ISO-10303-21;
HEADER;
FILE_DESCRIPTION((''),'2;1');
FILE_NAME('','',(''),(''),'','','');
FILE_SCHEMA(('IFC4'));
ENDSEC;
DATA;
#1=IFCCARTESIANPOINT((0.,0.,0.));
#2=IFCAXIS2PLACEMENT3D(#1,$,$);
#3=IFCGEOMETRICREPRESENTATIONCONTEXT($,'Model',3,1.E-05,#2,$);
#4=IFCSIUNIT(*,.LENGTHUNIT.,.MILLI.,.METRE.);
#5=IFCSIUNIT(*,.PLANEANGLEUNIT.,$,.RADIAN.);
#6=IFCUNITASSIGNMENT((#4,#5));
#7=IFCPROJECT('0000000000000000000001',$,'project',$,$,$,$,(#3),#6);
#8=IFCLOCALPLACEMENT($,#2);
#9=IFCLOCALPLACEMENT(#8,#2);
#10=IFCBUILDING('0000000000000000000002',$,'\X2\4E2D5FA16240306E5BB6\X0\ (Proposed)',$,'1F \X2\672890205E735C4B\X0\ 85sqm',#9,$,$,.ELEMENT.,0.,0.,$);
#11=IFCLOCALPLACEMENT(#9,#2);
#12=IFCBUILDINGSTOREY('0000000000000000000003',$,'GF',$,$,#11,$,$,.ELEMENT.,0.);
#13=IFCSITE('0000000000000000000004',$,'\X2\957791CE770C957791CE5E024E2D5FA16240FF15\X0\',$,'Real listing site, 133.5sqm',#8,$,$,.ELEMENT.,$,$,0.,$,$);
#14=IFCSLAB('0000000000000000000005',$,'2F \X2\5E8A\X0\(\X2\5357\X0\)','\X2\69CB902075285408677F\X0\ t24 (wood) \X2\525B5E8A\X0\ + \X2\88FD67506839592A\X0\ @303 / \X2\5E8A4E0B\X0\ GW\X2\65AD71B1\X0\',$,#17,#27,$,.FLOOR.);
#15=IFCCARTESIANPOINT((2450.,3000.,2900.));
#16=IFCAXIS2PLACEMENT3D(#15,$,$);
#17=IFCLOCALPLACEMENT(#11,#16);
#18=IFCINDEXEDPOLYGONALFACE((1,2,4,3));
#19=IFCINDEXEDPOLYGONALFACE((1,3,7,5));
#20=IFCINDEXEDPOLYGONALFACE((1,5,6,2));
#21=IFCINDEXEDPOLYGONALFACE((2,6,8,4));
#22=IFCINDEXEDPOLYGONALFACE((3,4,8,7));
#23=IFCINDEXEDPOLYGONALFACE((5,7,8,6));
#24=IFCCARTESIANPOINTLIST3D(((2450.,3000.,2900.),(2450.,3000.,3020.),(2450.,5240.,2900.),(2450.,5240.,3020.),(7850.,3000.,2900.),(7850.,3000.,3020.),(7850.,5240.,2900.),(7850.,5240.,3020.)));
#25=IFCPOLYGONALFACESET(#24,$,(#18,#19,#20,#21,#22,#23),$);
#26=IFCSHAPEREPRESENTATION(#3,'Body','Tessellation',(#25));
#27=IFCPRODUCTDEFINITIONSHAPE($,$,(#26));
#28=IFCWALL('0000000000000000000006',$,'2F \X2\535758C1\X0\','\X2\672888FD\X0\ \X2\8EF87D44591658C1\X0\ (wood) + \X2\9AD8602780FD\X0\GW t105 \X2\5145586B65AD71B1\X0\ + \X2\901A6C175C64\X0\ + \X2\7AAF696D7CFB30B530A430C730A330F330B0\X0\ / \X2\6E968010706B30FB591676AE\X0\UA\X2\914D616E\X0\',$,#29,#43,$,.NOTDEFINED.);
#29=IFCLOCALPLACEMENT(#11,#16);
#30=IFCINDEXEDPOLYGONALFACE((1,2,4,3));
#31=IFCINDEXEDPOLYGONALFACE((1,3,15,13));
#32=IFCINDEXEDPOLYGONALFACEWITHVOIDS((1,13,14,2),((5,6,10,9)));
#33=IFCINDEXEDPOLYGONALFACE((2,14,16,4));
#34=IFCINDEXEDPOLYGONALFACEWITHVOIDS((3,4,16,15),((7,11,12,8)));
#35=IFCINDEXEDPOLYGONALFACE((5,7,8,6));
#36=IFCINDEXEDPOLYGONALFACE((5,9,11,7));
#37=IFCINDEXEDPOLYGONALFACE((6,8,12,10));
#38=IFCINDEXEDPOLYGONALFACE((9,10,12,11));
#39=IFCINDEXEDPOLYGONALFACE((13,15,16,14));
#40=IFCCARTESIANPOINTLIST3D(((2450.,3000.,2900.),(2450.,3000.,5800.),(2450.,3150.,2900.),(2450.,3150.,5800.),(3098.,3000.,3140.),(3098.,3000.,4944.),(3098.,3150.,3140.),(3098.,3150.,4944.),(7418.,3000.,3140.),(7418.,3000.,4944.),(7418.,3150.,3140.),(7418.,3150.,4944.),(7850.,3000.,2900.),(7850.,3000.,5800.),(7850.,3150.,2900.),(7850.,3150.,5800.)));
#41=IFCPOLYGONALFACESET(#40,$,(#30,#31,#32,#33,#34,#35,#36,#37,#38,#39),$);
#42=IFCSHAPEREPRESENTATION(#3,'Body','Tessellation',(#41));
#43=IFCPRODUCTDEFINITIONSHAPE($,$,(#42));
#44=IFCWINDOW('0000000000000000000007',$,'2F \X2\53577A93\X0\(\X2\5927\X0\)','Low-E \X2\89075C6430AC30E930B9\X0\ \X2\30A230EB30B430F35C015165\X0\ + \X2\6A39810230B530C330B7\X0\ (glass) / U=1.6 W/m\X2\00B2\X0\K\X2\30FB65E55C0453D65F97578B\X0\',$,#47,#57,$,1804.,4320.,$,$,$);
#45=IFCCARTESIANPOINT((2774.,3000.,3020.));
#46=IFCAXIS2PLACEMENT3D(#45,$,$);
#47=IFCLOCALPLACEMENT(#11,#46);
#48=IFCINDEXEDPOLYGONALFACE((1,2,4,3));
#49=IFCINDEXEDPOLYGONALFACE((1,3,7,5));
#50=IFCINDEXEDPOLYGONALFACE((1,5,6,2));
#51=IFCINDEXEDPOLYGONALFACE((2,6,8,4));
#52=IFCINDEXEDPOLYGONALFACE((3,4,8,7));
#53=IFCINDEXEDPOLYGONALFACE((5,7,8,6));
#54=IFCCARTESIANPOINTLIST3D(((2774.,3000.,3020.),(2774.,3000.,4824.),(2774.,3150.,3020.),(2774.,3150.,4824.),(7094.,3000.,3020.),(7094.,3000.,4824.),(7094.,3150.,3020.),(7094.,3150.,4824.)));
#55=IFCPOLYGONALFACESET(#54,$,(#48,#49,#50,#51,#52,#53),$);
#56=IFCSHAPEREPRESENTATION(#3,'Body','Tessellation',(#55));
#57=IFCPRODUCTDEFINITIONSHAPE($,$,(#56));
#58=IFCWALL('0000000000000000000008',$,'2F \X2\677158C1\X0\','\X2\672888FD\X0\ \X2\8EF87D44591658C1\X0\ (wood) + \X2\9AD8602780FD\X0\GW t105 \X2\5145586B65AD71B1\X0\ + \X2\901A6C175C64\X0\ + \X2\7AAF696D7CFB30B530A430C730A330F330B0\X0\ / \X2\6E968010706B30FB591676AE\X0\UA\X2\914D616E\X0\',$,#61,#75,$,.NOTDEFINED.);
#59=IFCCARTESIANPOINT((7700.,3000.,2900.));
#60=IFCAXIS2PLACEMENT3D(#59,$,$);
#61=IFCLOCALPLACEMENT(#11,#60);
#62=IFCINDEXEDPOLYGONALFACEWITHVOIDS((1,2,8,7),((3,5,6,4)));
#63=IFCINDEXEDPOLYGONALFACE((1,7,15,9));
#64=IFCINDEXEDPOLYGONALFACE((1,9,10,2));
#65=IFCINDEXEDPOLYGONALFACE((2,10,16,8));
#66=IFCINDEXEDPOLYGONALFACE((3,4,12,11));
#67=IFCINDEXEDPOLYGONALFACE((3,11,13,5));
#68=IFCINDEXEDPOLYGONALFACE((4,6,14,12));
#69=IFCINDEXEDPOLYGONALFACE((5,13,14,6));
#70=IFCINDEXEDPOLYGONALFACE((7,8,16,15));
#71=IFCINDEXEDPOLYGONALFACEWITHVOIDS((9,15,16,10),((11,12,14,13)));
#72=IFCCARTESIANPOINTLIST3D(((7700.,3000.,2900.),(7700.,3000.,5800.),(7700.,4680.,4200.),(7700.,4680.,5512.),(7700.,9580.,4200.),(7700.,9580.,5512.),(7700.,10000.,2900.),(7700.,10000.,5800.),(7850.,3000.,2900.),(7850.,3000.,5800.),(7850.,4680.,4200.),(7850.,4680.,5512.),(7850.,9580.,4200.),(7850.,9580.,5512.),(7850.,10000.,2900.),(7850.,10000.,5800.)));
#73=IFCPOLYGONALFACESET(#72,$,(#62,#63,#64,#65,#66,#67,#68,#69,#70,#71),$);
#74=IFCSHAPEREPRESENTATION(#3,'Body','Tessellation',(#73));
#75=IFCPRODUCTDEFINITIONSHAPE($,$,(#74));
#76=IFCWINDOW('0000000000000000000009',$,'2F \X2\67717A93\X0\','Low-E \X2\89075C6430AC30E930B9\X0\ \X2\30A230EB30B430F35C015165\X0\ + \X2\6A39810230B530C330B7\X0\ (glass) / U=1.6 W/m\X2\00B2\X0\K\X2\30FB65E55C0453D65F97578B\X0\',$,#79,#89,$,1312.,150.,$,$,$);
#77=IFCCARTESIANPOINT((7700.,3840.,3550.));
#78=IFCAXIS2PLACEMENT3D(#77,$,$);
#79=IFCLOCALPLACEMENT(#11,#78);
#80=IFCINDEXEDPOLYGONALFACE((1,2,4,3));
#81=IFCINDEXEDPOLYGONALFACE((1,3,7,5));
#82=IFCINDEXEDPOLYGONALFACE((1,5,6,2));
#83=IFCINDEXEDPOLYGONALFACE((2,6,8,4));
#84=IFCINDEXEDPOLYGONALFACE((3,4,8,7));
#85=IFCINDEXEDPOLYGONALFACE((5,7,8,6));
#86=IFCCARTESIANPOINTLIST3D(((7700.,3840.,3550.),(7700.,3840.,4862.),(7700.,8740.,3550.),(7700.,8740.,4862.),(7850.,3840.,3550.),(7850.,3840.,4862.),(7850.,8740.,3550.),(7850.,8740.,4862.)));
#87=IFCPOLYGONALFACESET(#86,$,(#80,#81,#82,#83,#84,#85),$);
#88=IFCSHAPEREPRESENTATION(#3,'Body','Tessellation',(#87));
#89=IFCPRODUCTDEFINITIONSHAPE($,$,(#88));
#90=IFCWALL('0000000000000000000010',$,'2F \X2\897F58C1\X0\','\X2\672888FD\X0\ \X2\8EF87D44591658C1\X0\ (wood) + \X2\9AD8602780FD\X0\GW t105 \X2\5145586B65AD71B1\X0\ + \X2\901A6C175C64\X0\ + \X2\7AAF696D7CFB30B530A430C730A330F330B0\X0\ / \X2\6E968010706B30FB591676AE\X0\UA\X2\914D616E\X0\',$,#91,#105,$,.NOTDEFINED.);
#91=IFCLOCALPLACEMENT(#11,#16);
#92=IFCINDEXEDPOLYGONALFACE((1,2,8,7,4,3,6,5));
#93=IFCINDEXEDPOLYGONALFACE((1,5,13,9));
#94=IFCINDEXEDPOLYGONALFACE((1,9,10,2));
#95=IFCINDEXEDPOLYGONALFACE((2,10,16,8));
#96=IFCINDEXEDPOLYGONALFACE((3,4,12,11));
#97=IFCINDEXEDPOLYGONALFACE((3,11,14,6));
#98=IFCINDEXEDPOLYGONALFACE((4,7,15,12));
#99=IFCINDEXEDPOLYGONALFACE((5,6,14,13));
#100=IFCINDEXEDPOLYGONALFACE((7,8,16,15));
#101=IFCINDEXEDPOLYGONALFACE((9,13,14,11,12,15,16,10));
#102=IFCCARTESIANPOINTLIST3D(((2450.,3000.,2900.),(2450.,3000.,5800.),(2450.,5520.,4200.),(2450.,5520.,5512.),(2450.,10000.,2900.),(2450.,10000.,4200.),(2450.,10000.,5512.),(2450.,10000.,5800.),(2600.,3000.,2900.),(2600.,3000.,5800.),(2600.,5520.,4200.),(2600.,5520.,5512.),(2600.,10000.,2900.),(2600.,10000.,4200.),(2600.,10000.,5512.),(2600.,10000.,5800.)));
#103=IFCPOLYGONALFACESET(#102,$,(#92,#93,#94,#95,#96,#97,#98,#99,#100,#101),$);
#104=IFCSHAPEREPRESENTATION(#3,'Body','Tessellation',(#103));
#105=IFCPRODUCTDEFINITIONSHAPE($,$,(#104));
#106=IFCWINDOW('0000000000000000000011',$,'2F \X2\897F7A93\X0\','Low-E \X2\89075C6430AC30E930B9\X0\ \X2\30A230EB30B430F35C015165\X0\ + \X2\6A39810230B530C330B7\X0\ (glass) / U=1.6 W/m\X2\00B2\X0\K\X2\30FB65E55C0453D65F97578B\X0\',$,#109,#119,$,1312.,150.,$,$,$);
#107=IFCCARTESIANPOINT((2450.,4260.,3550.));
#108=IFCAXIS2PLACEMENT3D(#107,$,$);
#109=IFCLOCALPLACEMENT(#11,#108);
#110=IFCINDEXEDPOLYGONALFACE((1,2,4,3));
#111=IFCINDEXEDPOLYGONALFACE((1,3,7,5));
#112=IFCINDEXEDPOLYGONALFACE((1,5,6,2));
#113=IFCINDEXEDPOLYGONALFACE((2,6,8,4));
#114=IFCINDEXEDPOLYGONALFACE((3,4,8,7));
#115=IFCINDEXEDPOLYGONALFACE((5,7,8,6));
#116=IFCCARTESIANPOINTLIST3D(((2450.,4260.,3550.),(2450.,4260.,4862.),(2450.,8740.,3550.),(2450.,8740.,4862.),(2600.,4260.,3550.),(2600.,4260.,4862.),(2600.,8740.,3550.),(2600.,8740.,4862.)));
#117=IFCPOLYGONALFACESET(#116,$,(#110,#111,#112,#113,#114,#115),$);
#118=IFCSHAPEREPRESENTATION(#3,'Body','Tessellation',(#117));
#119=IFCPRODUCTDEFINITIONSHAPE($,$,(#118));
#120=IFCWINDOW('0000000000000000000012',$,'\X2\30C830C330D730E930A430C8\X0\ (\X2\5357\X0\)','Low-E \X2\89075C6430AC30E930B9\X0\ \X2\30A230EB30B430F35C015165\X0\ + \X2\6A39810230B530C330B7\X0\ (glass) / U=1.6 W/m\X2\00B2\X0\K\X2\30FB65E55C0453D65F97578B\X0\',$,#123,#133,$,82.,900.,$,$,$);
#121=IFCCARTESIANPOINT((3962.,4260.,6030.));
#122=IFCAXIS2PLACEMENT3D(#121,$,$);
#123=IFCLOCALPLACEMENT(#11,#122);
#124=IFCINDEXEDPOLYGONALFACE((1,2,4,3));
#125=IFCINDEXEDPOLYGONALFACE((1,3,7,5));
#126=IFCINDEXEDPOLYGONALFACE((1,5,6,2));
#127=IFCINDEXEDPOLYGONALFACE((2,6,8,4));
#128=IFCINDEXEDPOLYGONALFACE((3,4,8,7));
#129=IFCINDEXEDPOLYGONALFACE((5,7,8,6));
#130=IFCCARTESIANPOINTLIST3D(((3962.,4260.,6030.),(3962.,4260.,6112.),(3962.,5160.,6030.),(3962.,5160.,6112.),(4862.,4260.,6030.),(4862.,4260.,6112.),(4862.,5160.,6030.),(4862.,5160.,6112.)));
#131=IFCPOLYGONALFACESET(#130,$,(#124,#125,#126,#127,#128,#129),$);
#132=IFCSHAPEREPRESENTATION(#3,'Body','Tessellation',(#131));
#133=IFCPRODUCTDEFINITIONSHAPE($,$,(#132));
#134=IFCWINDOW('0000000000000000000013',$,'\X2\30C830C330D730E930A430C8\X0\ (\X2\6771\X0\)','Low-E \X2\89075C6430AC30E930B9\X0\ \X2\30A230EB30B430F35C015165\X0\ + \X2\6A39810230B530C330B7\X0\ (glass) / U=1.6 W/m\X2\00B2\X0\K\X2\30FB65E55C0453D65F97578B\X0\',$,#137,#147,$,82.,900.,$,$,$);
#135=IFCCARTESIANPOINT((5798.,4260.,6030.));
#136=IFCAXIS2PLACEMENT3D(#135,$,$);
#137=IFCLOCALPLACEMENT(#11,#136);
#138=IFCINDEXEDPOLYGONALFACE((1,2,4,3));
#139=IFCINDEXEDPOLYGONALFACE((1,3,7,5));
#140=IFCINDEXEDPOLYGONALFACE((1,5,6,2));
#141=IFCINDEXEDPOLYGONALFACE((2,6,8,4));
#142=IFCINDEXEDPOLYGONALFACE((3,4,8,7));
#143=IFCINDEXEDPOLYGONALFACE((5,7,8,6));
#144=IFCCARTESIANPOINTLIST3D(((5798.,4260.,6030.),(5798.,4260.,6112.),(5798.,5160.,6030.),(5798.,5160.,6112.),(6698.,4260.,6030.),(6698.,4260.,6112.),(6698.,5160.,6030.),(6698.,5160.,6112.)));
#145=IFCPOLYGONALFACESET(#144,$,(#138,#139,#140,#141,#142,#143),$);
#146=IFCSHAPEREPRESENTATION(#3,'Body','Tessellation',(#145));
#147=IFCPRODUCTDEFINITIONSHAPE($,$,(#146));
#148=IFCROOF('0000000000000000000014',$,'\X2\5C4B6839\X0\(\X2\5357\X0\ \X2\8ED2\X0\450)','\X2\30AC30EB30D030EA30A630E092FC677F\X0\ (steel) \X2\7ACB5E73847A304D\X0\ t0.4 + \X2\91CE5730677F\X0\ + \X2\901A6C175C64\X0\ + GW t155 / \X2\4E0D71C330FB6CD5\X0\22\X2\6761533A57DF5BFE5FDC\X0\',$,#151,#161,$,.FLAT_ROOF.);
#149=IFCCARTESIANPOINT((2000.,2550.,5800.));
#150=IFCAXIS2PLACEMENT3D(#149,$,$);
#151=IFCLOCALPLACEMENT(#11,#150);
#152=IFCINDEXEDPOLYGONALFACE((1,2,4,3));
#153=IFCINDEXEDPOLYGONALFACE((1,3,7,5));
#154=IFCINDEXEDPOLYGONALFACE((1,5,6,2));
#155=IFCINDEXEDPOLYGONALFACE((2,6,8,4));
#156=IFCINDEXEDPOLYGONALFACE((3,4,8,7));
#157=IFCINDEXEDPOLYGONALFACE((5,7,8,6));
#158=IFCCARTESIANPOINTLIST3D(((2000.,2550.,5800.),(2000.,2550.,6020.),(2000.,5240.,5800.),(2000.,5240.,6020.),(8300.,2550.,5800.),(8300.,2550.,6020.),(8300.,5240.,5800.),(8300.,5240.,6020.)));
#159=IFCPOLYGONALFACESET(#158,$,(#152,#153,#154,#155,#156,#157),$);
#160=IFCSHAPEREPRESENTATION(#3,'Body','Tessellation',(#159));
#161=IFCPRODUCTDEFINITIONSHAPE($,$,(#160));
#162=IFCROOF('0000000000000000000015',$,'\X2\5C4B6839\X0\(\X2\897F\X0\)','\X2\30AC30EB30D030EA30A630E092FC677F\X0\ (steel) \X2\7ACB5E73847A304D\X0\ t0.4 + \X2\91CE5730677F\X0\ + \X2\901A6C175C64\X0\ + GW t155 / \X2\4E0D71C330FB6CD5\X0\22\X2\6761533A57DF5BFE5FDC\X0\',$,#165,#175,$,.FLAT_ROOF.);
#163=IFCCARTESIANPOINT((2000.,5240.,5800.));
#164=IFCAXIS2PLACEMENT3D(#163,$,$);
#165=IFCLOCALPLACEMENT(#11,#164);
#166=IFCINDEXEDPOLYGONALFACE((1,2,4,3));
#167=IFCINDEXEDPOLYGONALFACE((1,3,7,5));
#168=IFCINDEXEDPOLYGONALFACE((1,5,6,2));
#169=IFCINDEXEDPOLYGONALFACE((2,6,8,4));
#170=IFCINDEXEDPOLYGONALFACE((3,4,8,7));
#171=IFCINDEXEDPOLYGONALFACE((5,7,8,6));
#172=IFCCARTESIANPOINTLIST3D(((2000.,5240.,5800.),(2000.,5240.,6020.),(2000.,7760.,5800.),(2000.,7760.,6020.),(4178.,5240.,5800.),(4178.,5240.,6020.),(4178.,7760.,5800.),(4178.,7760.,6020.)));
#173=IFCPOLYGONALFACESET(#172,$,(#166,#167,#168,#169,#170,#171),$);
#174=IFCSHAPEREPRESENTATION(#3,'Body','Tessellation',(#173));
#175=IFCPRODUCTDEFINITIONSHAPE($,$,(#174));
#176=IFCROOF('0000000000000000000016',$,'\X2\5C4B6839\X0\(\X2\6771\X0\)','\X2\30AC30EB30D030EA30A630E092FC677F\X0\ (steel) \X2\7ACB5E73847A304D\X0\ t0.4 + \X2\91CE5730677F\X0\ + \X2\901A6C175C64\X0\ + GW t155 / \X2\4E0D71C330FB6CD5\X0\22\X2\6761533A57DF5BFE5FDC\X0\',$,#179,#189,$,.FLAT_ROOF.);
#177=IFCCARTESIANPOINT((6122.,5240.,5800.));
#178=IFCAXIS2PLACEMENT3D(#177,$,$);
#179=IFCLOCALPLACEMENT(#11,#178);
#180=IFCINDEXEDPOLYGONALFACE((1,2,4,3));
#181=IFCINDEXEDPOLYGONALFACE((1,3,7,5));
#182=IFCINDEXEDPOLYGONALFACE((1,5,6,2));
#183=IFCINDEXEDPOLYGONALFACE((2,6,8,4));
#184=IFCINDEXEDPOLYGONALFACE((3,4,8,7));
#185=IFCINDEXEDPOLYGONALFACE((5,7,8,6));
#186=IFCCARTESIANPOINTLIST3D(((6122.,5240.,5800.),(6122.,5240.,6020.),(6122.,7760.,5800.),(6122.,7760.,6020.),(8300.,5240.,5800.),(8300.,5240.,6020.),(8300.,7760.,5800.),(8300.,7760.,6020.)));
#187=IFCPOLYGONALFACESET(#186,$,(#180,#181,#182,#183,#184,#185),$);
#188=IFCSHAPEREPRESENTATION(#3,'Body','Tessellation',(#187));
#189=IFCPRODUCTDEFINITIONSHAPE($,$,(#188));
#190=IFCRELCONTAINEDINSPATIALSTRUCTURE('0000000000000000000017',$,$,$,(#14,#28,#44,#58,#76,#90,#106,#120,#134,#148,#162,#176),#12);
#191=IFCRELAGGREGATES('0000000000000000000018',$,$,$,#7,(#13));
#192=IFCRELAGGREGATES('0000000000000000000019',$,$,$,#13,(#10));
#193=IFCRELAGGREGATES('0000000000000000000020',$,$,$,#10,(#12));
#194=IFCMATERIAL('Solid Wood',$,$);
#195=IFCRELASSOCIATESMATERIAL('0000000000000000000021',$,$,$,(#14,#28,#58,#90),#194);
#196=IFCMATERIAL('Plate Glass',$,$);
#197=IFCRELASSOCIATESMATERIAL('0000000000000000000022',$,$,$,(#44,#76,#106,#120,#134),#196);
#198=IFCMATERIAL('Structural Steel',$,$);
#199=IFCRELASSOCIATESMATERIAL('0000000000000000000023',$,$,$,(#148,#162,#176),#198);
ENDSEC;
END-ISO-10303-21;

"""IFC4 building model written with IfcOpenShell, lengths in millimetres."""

from ifc_helpers import new_model, si_unit, frame, frame_2d, origin, place, context, project, spatial, rectangle, extrude, material, element, fill, save


model = new_model("IFC4")

# Units and contexts
model_context = context("Model", 3, precision=1e-05, world=origin())
ifc_project = project(units=[si_unit("LENGTHUNIT", "METRE", prefix="MILLI"), si_unit("PLANEANGLEUNIT", "RADIAN")], contexts=[model_context])

# Site, building, storey
site_placement = place(None, origin())
site = spatial("IfcSite", under=ifc_project, at=site_placement, Name="長野県長野市中御所５", ObjectType="Real listing site, 133.5sqm", CompositionType="ELEMENT", RefElevation=0.0)
building_placement = place(site_placement, origin())
building = spatial("IfcBuilding", under=site, at=building_placement, Name="中御所の家 (Proposed)", ObjectType="1F 木造平屋 85sqm", CompositionType="ELEMENT", ElevationOfRefHeight=0.0, ElevationOfTerrain=0.0)
storey_placement = place(building_placement, origin())
storey = spatial("IfcBuildingStorey", under=building, at=storey_placement, Name="GF", CompositionType="ELEMENT", Elevation=0.0)

# Slab
ifc_material_1 = material(Name="Solid Wood")
slab_placement = place(storey_placement, frame((2450.0, 3000.0, 2900.0)))
element("IfcSlab", 1, at=slab_placement, inside=storey, material=ifc_material_1, Name="2F 床(南)", Description="構造用合板 t24 (wood) 剛床 + 製材根太 @303 / 床下 GW断熱", PredefinedType="FLOOR", context=model_context, shape_type="SweptSolid", body=[
    extrude(rectangle(XDim=5400.0, YDim=2240.0, at=frame_2d((2700.0, 1120.0))), frame((2450.0, 3000.0, 2900.0)), (0.0, 0.0, 1.0), 120.0),
])

# Walls, openings, windows
wall_1_placement = place(storey_placement, frame((2450.0, 3000.0, 2900.0)))
wall_1 = element("IfcWall", 2, at=wall_1_placement, inside=storey, material=ifc_material_1, Name="2F 南壁", Description="木製 軸組外壁 (wood) + 高性能GW t105 充填断熱 + 通気層 + 窯業系サイディング / 準耐火・外皮UA配慮", PredefinedType="NOTDEFINED", context=model_context, shape_type="SweptSolid", body=[
    extrude(rectangle(XDim=5400.0, YDim=150.0, at=frame_2d((2700.0, 75.0))), frame((2450.0, 3000.0, 2900.0)), (0.0, 0.0, 1.0), 2900.0),
])
opening_1_placement = place(storey_placement, frame((2774.0, 3000.0, 3020.0)))
opening_1 = element("IfcOpeningElement", 3, at=opening_1_placement, cuts=wall_1, PredefinedType="NOTDEFINED", context=model_context, shape_type="SweptSolid", body=[
    extrude(rectangle(XDim=4320.0, YDim=150.0, at=frame_2d((2160.0, 75.0))), frame((2774.0, 3000.0, 3020.0)), (0.0, 0.0, 1.0), 1804.0),
])
ifc_material_2 = material(Name="Plate Glass")
window_1_placement = place(storey_placement, frame((2774.0, 3000.0, 3020.0)))
window_1 = element("IfcWindow", 4, at=window_1_placement, inside=storey, material=ifc_material_2, Name="2F 南窓(大)", Description="Low-E 複層ガラス アルゴン封入 + 樹脂サッシ (glass) / U=1.6 W/m²K・日射取得型", OverallHeight=1804.0, OverallWidth=4320.0, context=model_context, shape_type="SweptSolid", body=[
    extrude(rectangle(XDim=4320.0, YDim=150.0, at=frame_2d((2160.0, 75.0))), frame((2774.0, 3000.0, 3020.0)), (0.0, 0.0, 1.0), 1804.0),
])
fill(opening_1, window_1)
wall_2_placement = place(storey_placement, frame((7700.0, 3000.0, 2900.0)))
wall_2 = element("IfcWall", 5, at=wall_2_placement, inside=storey, material=ifc_material_1, Name="2F 東壁", Description="木製 軸組外壁 (wood) + 高性能GW t105 充填断熱 + 通気層 + 窯業系サイディング / 準耐火・外皮UA配慮", PredefinedType="NOTDEFINED", context=model_context, shape_type="SweptSolid", body=[
    extrude(rectangle(XDim=150.0, YDim=7000.0, at=frame_2d((75.0, 3500.0))), frame((7700.0, 3000.0, 2900.0)), (0.0, 0.0, 1.0), 2900.0),
])
opening_2_placement = place(storey_placement, frame((7700.0, 3840.0, 3550.0)))
opening_2 = element("IfcOpeningElement", 6, at=opening_2_placement, cuts=wall_2, PredefinedType="NOTDEFINED", context=model_context, shape_type="SweptSolid", body=[
    extrude(rectangle(XDim=150.0, YDim=4900.0, at=frame_2d((75.0, 2450.0))), frame((7700.0, 3840.0, 3550.0)), (0.0, 0.0, 1.0), 1312.0),
])
window_2_placement = place(storey_placement, frame((7700.0, 3840.0, 3550.0)))
window_2 = element("IfcWindow", 7, at=window_2_placement, inside=storey, material=ifc_material_2, Name="2F 東窓", Description="Low-E 複層ガラス アルゴン封入 + 樹脂サッシ (glass) / U=1.6 W/m²K・日射取得型", OverallHeight=1312.0, OverallWidth=150.0, context=model_context, shape_type="SweptSolid", body=[
    extrude(rectangle(XDim=150.0, YDim=4900.0, at=frame_2d((75.0, 2450.0))), frame((7700.0, 3840.0, 3550.0)), (0.0, 0.0, 1.0), 1312.0),
])
fill(opening_2, window_2)
wall_3_placement = place(storey_placement, frame((2450.0, 3000.0, 2900.0)))
wall_3 = element("IfcWall", 8, at=wall_3_placement, inside=storey, material=ifc_material_1, Name="2F 西壁", Description="木製 軸組外壁 (wood) + 高性能GW t105 充填断熱 + 通気層 + 窯業系サイディング / 準耐火・外皮UA配慮", PredefinedType="NOTDEFINED", context=model_context, shape_type="SweptSolid", body=[
    extrude(rectangle(XDim=150.0, YDim=7000.0, at=frame_2d((75.0, 3500.0))), frame((2450.0, 3000.0, 2900.0)), (0.0, 0.0, 1.0), 2900.0),
])
opening_3_placement = place(storey_placement, frame((2450.0, 4260.0, 3550.0)))
opening_3 = element("IfcOpeningElement", 9, at=opening_3_placement, cuts=wall_3, PredefinedType="NOTDEFINED", context=model_context, shape_type="SweptSolid", body=[
    extrude(rectangle(XDim=150.0, YDim=4480.0, at=frame_2d((75.0, 2240.0))), frame((2450.0, 4260.0, 3550.0)), (0.0, 0.0, 1.0), 1312.0),
])
window_3_placement = place(storey_placement, frame((2450.0, 4260.0, 3550.0)))
window_3 = element("IfcWindow", 10, at=window_3_placement, inside=storey, material=ifc_material_2, Name="2F 西窓", Description="Low-E 複層ガラス アルゴン封入 + 樹脂サッシ (glass) / U=1.6 W/m²K・日射取得型", OverallHeight=1312.0, OverallWidth=150.0, context=model_context, shape_type="SweptSolid", body=[
    extrude(rectangle(XDim=150.0, YDim=4480.0, at=frame_2d((75.0, 2240.0))), frame((2450.0, 4260.0, 3550.0)), (0.0, 0.0, 1.0), 1312.0),
])
fill(opening_3, window_3)

# Windows
window_4_placement = place(storey_placement, frame((3962.0, 4260.0, 6030.0)))
element("IfcWindow", 11, at=window_4_placement, inside=storey, material=ifc_material_2, Name="トップライト (南)", Description="Low-E 複層ガラス アルゴン封入 + 樹脂サッシ (glass) / U=1.6 W/m²K・日射取得型", OverallHeight=82.0, OverallWidth=900.0, context=model_context, shape_type="SweptSolid", body=[
    extrude(rectangle(XDim=900.0, YDim=900.0, at=frame_2d((450.0, 450.0))), frame((3962.0, 4260.0, 6030.0)), (0.0, 0.0, 1.0), 82.0),
])
window_5_placement = place(storey_placement, frame((5798.0, 4260.0, 6030.0)))
element("IfcWindow", 12, at=window_5_placement, inside=storey, material=ifc_material_2, Name="トップライト (東)", Description="Low-E 複層ガラス アルゴン封入 + 樹脂サッシ (glass) / U=1.6 W/m²K・日射取得型", OverallHeight=82.0, OverallWidth=900.0, context=model_context, shape_type="SweptSolid", body=[
    extrude(rectangle(XDim=900.0, YDim=900.0, at=frame_2d((450.0, 450.0))), frame((5798.0, 4260.0, 6030.0)), (0.0, 0.0, 1.0), 82.0),
])

# Roofs
ifc_material_3 = material(Name="Structural Steel")
roof_1_placement = place(storey_placement, frame((2000.0, 2550.0, 5800.0)))
element("IfcRoof", 13, at=roof_1_placement, inside=storey, material=ifc_material_3, Name="屋根(南 軒450)", Description="ガルバリウム鋼板 (steel) 立平葺き t0.4 + 野地板 + 通気層 + GW t155 / 不燃・法22条区域対応", PredefinedType="FLAT_ROOF", context=model_context, shape_type="SweptSolid", body=[
    extrude(rectangle(XDim=6300.0, YDim=2690.0, at=frame_2d((3150.0, 1345.0))), frame((2000.0, 2550.0, 5800.0)), (0.0, 0.0, 1.0), 220.0),
])
roof_2_placement = place(storey_placement, frame((2000.0, 5240.0, 5800.0)))
element("IfcRoof", 14, at=roof_2_placement, inside=storey, material=ifc_material_3, Name="屋根(西)", Description="ガルバリウム鋼板 (steel) 立平葺き t0.4 + 野地板 + 通気層 + GW t155 / 不燃・法22条区域対応", PredefinedType="FLAT_ROOF", context=model_context, shape_type="SweptSolid", body=[
    extrude(rectangle(XDim=2178.0, YDim=2520.0, at=frame_2d((1089.0, 1260.0))), frame((2000.0, 5240.0, 5800.0)), (0.0, 0.0, 1.0), 220.0),
])
roof_3_placement = place(storey_placement, frame((6122.0, 5240.0, 5800.0)))
element("IfcRoof", 15, at=roof_3_placement, inside=storey, material=ifc_material_3, Name="屋根(東)", Description="ガルバリウム鋼板 (steel) 立平葺き t0.4 + 野地板 + 通気層 + GW t155 / 不燃・法22条区域対応", PredefinedType="FLAT_ROOF", context=model_context, shape_type="SweptSolid", body=[
    extrude(rectangle(XDim=2178.0, YDim=2520.0, at=frame_2d((1089.0, 1260.0))), frame((6122.0, 5240.0, 5800.0)), (0.0, 0.0, 1.0), 220.0),
])

save(model, "model.ifc")
